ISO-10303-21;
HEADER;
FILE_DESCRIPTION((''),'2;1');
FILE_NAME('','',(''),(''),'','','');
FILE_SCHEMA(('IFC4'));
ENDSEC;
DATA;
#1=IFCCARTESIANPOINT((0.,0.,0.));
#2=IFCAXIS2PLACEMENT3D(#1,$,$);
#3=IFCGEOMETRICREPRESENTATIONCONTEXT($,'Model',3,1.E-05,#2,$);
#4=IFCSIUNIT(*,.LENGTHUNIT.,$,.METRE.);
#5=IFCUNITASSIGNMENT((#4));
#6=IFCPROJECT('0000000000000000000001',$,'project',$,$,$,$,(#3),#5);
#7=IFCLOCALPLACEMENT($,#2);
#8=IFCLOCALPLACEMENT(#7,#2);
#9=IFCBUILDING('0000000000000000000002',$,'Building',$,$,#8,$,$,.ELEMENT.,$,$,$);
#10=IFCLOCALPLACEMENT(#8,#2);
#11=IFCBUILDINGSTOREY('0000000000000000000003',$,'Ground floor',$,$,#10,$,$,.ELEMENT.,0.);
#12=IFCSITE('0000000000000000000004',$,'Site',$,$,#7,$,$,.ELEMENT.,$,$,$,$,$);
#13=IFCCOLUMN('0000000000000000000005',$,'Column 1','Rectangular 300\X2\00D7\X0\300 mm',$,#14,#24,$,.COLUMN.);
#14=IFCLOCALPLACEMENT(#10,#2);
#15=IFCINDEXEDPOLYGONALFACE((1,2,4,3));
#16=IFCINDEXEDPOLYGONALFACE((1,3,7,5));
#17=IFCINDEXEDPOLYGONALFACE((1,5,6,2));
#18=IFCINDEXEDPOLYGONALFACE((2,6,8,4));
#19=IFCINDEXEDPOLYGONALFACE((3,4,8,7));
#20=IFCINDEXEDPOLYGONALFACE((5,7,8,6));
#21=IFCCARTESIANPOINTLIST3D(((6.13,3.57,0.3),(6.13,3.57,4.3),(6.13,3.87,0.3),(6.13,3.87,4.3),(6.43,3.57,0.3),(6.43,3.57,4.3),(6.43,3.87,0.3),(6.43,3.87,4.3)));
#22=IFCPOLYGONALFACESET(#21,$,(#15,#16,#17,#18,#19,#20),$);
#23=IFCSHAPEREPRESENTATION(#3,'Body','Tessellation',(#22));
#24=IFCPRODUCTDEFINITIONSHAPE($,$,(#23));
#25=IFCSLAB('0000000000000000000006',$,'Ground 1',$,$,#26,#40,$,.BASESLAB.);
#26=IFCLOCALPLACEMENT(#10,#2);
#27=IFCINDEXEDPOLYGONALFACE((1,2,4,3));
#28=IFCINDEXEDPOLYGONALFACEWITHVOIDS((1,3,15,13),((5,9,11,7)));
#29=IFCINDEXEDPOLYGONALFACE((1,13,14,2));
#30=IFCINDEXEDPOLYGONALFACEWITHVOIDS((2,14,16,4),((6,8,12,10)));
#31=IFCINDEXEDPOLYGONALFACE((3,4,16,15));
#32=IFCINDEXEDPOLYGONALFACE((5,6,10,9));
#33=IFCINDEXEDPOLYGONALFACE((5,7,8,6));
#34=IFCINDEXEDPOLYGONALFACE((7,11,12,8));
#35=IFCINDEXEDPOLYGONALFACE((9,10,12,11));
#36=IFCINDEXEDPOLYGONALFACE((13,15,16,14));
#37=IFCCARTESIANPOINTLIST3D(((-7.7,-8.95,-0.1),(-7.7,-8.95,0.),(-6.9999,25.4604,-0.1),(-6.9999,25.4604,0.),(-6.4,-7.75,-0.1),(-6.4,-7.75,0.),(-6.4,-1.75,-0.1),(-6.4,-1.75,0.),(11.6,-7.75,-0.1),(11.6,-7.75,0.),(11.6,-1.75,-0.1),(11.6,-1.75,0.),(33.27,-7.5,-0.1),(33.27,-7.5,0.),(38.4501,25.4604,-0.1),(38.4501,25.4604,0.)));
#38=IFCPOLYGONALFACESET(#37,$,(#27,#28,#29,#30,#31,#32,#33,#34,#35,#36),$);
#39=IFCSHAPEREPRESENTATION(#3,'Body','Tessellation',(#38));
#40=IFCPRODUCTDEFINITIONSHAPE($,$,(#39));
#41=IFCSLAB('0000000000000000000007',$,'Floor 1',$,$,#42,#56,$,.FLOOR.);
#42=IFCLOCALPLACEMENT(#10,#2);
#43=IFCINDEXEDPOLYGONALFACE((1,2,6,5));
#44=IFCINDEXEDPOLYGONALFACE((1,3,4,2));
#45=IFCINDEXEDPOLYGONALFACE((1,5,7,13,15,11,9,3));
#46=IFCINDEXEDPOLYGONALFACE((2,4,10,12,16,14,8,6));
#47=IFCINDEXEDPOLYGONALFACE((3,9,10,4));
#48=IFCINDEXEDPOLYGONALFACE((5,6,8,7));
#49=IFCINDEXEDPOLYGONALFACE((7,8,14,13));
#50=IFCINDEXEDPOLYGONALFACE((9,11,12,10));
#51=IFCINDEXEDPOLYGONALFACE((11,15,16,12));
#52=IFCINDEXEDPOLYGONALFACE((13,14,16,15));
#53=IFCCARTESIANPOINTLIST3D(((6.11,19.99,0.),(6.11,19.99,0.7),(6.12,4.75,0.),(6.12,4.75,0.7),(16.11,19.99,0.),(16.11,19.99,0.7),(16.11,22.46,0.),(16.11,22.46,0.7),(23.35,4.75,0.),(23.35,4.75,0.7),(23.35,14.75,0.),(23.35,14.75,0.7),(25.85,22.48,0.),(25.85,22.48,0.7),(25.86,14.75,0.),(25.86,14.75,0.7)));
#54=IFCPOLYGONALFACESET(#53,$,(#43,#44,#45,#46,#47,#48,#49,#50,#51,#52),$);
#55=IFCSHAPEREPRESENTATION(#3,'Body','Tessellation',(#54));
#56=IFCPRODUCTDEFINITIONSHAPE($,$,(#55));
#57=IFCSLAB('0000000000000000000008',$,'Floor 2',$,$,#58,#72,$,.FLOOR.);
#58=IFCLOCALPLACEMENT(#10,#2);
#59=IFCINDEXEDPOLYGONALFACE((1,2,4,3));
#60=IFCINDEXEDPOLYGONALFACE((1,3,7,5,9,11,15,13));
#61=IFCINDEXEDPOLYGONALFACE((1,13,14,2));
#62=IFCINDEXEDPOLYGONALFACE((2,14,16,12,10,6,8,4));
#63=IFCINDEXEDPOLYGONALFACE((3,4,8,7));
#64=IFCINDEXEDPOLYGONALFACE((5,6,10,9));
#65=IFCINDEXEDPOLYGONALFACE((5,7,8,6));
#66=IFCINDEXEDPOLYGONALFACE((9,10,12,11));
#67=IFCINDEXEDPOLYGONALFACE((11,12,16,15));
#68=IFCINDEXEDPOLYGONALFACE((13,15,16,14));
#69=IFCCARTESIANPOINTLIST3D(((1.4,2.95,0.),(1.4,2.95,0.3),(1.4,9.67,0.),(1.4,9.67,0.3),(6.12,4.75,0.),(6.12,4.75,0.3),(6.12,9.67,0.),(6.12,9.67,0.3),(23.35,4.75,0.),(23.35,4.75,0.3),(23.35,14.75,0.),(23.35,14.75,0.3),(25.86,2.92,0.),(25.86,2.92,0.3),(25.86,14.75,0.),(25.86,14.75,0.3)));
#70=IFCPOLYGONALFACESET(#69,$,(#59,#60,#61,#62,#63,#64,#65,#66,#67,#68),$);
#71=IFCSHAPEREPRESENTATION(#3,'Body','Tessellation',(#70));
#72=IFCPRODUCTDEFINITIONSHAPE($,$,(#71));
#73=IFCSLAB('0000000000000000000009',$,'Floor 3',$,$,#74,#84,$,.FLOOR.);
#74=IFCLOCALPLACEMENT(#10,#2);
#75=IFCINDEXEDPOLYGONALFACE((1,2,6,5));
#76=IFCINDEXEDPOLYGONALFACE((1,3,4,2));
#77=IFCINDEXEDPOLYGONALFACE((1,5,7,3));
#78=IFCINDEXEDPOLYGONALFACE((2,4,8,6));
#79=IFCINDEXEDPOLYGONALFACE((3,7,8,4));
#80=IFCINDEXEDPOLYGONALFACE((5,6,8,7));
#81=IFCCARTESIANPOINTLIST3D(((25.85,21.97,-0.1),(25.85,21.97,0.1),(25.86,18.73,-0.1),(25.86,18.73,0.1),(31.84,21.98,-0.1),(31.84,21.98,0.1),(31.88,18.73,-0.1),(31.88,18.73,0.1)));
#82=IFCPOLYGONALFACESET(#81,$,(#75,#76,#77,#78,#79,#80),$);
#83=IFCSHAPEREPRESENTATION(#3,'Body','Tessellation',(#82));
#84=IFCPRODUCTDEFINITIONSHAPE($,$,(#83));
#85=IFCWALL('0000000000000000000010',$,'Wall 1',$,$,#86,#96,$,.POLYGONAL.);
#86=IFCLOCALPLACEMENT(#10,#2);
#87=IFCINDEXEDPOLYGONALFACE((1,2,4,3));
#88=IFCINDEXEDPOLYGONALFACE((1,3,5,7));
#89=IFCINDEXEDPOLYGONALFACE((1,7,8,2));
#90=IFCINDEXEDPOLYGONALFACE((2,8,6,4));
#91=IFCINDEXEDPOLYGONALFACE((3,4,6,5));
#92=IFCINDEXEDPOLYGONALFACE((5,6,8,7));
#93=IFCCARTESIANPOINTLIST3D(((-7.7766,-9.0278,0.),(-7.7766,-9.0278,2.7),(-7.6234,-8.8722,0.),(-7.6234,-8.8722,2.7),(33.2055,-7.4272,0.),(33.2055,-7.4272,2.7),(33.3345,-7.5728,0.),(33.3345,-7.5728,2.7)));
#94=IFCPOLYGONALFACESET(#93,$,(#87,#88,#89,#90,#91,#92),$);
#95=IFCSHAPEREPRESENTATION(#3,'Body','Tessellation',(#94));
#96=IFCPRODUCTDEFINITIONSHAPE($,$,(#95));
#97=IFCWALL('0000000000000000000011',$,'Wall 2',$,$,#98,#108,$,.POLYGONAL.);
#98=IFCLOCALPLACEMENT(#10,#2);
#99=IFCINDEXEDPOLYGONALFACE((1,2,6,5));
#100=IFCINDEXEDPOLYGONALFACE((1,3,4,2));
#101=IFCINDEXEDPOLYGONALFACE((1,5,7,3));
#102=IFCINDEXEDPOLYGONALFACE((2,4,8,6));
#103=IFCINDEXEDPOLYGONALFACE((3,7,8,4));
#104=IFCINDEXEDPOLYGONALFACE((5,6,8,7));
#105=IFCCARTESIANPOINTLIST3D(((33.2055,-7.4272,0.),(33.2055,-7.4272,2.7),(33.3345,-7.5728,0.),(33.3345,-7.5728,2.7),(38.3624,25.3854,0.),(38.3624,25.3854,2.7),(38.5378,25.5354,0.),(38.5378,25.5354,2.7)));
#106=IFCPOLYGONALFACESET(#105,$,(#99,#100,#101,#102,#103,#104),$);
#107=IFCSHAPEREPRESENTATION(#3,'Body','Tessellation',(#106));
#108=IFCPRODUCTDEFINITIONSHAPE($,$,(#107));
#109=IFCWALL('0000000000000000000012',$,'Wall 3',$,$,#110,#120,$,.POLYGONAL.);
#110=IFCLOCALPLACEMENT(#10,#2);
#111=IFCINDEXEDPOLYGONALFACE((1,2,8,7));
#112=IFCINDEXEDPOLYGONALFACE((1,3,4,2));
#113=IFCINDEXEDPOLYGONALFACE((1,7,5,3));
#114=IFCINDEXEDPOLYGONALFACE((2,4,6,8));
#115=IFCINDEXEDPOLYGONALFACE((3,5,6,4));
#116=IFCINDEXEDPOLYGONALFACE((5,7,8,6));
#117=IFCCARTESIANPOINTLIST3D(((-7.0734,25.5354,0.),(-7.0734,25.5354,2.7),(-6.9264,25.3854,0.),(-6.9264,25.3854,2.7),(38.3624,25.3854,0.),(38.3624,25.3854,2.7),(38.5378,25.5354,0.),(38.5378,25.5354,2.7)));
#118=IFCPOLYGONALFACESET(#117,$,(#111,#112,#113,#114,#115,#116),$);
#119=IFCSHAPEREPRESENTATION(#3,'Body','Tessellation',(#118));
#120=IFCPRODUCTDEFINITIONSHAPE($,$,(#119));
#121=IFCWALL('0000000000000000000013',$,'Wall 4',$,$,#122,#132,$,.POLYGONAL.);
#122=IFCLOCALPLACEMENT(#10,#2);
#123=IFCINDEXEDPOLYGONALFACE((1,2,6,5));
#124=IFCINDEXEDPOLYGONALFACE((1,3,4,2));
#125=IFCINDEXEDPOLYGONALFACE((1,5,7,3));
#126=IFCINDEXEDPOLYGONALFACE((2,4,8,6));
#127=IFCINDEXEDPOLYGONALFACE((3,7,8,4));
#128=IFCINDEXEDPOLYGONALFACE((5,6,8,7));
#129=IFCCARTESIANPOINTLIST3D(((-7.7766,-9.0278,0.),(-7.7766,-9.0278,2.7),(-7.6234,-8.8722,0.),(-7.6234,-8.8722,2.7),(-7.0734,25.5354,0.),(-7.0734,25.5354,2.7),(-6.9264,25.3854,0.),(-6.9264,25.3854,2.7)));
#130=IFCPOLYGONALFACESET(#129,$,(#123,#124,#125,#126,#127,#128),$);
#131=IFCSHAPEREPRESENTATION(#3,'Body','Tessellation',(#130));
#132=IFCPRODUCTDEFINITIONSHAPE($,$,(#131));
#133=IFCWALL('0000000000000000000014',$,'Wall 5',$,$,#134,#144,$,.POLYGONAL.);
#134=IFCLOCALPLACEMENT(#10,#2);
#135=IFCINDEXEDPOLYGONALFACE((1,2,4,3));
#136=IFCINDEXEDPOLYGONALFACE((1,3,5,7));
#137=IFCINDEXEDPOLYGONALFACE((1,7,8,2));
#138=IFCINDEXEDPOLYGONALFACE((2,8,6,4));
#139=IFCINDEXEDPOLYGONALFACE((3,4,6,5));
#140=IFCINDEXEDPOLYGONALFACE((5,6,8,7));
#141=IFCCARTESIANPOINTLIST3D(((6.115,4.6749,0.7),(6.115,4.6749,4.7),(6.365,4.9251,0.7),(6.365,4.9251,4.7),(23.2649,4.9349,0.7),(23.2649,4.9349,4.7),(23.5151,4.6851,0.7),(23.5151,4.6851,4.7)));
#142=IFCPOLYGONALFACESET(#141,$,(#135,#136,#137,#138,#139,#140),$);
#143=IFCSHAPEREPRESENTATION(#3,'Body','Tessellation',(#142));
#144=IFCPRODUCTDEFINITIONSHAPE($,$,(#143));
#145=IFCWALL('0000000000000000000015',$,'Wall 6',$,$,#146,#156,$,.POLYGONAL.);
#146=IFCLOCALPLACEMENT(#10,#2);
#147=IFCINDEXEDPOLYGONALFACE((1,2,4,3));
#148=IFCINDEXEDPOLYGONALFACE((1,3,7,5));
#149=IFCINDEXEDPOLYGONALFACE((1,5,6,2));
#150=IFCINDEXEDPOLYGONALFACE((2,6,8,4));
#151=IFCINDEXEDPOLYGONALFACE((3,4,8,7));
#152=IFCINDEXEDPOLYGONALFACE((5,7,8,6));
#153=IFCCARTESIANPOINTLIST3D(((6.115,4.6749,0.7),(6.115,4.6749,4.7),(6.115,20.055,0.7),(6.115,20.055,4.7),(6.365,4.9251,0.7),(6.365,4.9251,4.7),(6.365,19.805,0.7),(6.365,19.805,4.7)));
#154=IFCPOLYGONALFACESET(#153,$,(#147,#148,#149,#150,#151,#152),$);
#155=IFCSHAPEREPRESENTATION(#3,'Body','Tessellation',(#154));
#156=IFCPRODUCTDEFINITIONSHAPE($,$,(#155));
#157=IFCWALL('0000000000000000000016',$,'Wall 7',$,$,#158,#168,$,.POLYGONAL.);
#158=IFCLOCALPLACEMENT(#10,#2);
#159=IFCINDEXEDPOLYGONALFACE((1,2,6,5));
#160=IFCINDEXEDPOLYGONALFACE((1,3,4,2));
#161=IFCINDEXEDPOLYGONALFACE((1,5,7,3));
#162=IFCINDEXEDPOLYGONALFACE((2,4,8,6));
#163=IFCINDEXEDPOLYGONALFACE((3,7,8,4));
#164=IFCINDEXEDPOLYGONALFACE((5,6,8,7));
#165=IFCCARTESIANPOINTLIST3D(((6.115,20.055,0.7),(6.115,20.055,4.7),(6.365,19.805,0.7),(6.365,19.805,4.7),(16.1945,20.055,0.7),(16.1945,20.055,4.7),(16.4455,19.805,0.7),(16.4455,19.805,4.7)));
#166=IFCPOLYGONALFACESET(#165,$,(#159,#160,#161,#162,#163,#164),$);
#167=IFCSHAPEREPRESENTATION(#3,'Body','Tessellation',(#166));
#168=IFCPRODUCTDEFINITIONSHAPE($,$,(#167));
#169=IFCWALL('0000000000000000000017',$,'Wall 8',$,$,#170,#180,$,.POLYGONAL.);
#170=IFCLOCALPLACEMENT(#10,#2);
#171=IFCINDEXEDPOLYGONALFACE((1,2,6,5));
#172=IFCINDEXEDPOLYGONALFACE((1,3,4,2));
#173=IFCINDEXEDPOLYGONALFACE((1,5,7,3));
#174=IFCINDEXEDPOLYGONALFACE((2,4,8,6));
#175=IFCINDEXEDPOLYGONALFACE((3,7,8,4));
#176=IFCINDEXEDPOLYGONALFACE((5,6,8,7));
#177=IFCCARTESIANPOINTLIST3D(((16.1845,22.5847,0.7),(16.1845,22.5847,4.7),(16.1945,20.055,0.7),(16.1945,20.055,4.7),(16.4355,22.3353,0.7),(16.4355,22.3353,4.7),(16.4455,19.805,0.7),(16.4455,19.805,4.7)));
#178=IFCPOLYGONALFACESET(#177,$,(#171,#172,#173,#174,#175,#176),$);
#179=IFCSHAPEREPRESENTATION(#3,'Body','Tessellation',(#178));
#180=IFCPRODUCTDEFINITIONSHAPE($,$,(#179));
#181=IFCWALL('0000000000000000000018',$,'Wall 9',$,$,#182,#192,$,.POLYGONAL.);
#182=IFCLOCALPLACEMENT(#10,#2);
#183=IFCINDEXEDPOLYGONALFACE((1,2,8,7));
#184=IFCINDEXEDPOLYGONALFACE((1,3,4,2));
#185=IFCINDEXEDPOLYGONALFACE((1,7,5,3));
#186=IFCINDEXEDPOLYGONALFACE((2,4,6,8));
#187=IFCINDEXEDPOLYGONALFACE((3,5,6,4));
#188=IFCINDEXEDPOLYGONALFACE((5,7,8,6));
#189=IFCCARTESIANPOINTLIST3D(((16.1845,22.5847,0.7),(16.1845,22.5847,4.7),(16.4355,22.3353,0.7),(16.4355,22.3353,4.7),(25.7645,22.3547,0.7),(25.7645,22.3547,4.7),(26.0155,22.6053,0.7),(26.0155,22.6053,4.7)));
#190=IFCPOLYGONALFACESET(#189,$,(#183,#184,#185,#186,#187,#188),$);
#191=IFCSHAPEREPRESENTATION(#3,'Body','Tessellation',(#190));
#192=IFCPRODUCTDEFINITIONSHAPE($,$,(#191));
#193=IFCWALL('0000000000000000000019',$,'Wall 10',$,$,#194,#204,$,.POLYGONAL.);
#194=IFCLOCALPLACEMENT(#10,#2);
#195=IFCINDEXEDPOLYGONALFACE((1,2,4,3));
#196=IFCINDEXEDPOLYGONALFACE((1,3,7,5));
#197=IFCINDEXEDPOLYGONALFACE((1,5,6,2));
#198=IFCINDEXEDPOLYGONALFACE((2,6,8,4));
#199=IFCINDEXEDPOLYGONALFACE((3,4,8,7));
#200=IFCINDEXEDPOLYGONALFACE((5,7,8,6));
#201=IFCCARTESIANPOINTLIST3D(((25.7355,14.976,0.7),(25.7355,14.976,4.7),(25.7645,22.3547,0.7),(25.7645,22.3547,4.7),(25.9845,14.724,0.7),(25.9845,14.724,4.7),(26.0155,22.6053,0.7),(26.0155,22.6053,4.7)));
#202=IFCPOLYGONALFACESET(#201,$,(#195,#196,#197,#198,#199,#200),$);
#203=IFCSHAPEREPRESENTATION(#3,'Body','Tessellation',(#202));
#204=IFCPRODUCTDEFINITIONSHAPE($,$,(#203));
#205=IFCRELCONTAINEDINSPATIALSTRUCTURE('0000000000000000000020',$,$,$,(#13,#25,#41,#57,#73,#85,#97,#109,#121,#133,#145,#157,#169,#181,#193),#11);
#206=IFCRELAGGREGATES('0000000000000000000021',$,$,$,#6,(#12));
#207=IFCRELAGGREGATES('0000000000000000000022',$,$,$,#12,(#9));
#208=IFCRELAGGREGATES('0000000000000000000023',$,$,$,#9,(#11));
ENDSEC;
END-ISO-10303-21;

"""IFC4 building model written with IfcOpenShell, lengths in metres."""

from ifc_helpers import new_model, si_unit, frame, origin, origin_with_axes, place, context, project, spatial, polyline, outline, extrude, element, save


model = new_model("IFC4")

# Units and contexts
model_context = context("Model", 3, precision=1e-05, world=origin())
ifc_project = project(units=[si_unit("LENGTHUNIT", "METRE")], contexts=[model_context])

# Site, building, storey
site_placement = place(None, origin())
site = spatial("IfcSite", under=ifc_project, at=site_placement, Name="Site", CompositionType="ELEMENT")
building_placement = place(site_placement, origin())
building = spatial("IfcBuilding", under=site, at=building_placement, Name="Building", CompositionType="ELEMENT")
storey_placement = place(building_placement, origin())
storey = spatial("IfcBuildingStorey", under=building, at=storey_placement, Name="Ground floor", CompositionType="ELEMENT", Elevation=0.0)

# Column
column_placement = place(storey_placement, frame((6.28, 3.72, 0.3), z_axis=(0.0, 0.0, 1.0), x_axis=(1.0, 0.0, 0.0)))
element("IfcColumn", 1, at=column_placement, inside=storey, Name="Column 1", Description="Rectangular 300×300 mm", PredefinedType="COLUMN", context=model_context, shape_type="SweptSolid", body=[
    extrude(outline(polyline([(-0.15, -0.15), (0.15, -0.15), (0.15, 0.15), (-0.15, 0.15), (-0.15, -0.15)])), origin(), (0.0, 0.0, 1.0), 4.0),
])

# Slabs
slab_1_placement = place(storey_placement, frame((0.0, 0.0, -0.1), z_axis=(0.0, 0.0, 1.0), x_axis=(1.0, 0.0, 0.0)))
element("IfcSlab", 2, at=slab_1_placement, inside=storey, Name="Ground 1", PredefinedType="BASESLAB", context=model_context, shape_type="SweptSolid", body=[
    extrude(outline(polyline([(-7.7, -8.95), (-6.9999, 25.4604), (38.4501, 25.4604), (33.27, -7.5), (-7.7, -8.95)]), holes=[polyline([(-6.4, -7.75), (11.6, -7.75), (11.6, -1.75), (-6.4, -1.75), (-6.4, -7.75)])]), origin(), (0.0, 0.0, 1.0), 0.1),
])
slab_2_placement = place(storey_placement, origin_with_axes())
element("IfcSlab", 3, at=slab_2_placement, inside=storey, Name="Floor 1", PredefinedType="FLOOR", context=model_context, shape_type="SweptSolid", body=[
    extrude(outline(polyline([(6.12, 4.75), (6.11, 19.99), (16.11, 19.99), (16.11, 22.46), (25.85, 22.48), (25.86, 14.75), (23.35, 14.75), (23.35, 4.75), (6.12, 4.75)])), origin(), (0.0, 0.0, 1.0), 0.7),
])
slab_3_placement = place(storey_placement, origin_with_axes())
element("IfcSlab", 4, at=slab_3_placement, inside=storey, Name="Floor 2", PredefinedType="FLOOR", context=model_context, shape_type="SweptSolid", body=[
    extrude(outline(polyline([(25.86, 14.75), (25.86, 2.92), (1.4, 2.95), (1.4, 9.67), (6.12, 9.67), (6.12, 4.75), (23.35, 4.75), (23.35, 14.75), (25.86, 14.75)])), origin(), (0.0, 0.0, 1.0), 0.3),
])
slab_4_placement = place(storey_placement, frame((0.0, 0.0, -0.1), z_axis=(0.0, 0.0, 1.0), x_axis=(1.0, 0.0, 0.0)))
element("IfcSlab", 5, at=slab_4_placement, inside=storey, Name="Floor 3", PredefinedType="FLOOR", context=model_context, shape_type="SweptSolid", body=[
    extrude(outline(polyline([(25.85, 21.97), (31.84, 21.98), (31.88, 18.73), (25.86, 18.73), (25.85, 21.97)])), origin(), (0.0, 0.0, 1.0), 0.2),
])

# Walls
wall_1_placement = place(storey_placement, origin_with_axes())
element("IfcWall", 6, at=wall_1_placement, inside=storey, Name="Wall 1", PredefinedType="POLYGONAL", context=model_context, shape_type="SweptSolid", body=[
    extrude(outline(polyline([(-7.6234, -8.8722), (-7.7766, -9.0278), (33.3345, -7.5728), (33.2055, -7.4272), (-7.6234, -8.8722)])), origin(), (0.0, 0.0, 1.0), 2.7),
])
wall_2_placement = place(storey_placement, origin_with_axes())
element("IfcWall", 7, at=wall_2_placement, inside=storey, Name="Wall 2", PredefinedType="POLYGONAL", context=model_context, shape_type="SweptSolid", body=[
    extrude(outline(polyline([(33.2055, -7.4272), (33.3345, -7.5728), (38.5378, 25.5354), (38.3624, 25.3854), (33.2055, -7.4272)])), origin(), (0.0, 0.0, 1.0), 2.7),
])
wall_3_placement = place(storey_placement, origin_with_axes())
element("IfcWall", 8, at=wall_3_placement, inside=storey, Name="Wall 3", PredefinedType="POLYGONAL", context=model_context, shape_type="SweptSolid", body=[
    extrude(outline(polyline([(38.3624, 25.3854), (38.5378, 25.5354), (-7.0734, 25.5354), (-6.9264, 25.3854), (38.3624, 25.3854)])), origin(), (0.0, 0.0, 1.0), 2.7),
])
wall_4_placement = place(storey_placement, origin_with_axes())
element("IfcWall", 9, at=wall_4_placement, inside=storey, Name="Wall 4", PredefinedType="POLYGONAL", context=model_context, shape_type="SweptSolid", body=[
    extrude(outline(polyline([(-6.9264, 25.3854), (-7.0734, 25.5354), (-7.7766, -9.0278), (-7.6234, -8.8722), (-6.9264, 25.3854)])), origin(), (0.0, 0.0, 1.0), 2.7),
])
wall_5_placement = place(storey_placement, frame((0.0, 0.0, 0.7), z_axis=(0.0, 0.0, 1.0), x_axis=(1.0, 0.0, 0.0)))
element("IfcWall", 10, at=wall_5_placement, inside=storey, Name="Wall 5", PredefinedType="POLYGONAL", context=model_context, shape_type="SweptSolid", body=[
    extrude(outline(polyline([(6.365, 4.9251), (6.115, 4.6749), (23.5151, 4.6851), (23.2649, 4.9349), (6.365, 4.9251)])), origin(), (0.0, 0.0, 1.0), 4.0),
])
wall_6_placement = place(storey_placement, frame((0.0, 0.0, 0.7), z_axis=(0.0, 0.0, 1.0), x_axis=(1.0, 0.0, 0.0)))
element("IfcWall", 11, at=wall_6_placement, inside=storey, Name="Wall 6", PredefinedType="POLYGONAL", context=model_context, shape_type="SweptSolid", body=[
    extrude(outline(polyline([(6.115, 4.6749), (6.365, 4.9251), (6.365, 19.805), (6.115, 20.055), (6.115, 4.6749)])), origin(), (0.0, 0.0, 1.0), 4.0),
])
wall_7_placement = place(storey_placement, frame((0.0, 0.0, 0.7), z_axis=(0.0, 0.0, 1.0), x_axis=(1.0, 0.0, 0.0)))
element("IfcWall", 12, at=wall_7_placement, inside=storey, Name="Wall 7", PredefinedType="POLYGONAL", context=model_context, shape_type="SweptSolid", body=[
    extrude(outline(polyline([(16.4455, 19.805), (16.1945, 20.055), (6.115, 20.055), (6.365, 19.805), (16.4455, 19.805)])), origin(), (0.0, 0.0, 1.0), 4.0),
])
wall_8_placement = place(storey_placement, frame((0.0, 0.0, 0.7), z_axis=(0.0, 0.0, 1.0), x_axis=(1.0, 0.0, 0.0)))
element("IfcWall", 13, at=wall_8_placement, inside=storey, Name="Wall 8", PredefinedType="POLYGONAL", context=model_context, shape_type="SweptSolid", body=[
    extrude(outline(polyline([(16.1945, 20.055), (16.4455, 19.805), (16.4355, 22.3353), (16.1845, 22.5847), (16.1945, 20.055)])), origin(), (0.0, 0.0, 1.0), 4.0),
])
wall_9_placement = place(storey_placement, frame((0.0, 0.0, 0.7), z_axis=(0.0, 0.0, 1.0), x_axis=(1.0, 0.0, 0.0)))
element("IfcWall", 14, at=wall_9_placement, inside=storey, Name="Wall 9", PredefinedType="POLYGONAL", context=model_context, shape_type="SweptSolid", body=[
    extrude(outline(polyline([(25.7645, 22.3547), (26.0155, 22.6053), (16.1845, 22.5847), (16.4355, 22.3353), (25.7645, 22.3547)])), origin(), (0.0, 0.0, 1.0), 4.0),
])
wall_10_placement = place(storey_placement, frame((0.0, 0.0, 0.7), z_axis=(0.0, 0.0, 1.0), x_axis=(1.0, 0.0, 0.0)))
element("IfcWall", 15, at=wall_10_placement, inside=storey, Name="Wall 10", PredefinedType="POLYGONAL", context=model_context, shape_type="SweptSolid", body=[
    extrude(outline(polyline([(26.0155, 22.6053), (25.7645, 22.3547), (25.7355, 14.976), (25.9845, 14.724), (26.0155, 22.6053)])), origin(), (0.0, 0.0, 1.0), 4.0),
])

save(model, "model.ifc")
